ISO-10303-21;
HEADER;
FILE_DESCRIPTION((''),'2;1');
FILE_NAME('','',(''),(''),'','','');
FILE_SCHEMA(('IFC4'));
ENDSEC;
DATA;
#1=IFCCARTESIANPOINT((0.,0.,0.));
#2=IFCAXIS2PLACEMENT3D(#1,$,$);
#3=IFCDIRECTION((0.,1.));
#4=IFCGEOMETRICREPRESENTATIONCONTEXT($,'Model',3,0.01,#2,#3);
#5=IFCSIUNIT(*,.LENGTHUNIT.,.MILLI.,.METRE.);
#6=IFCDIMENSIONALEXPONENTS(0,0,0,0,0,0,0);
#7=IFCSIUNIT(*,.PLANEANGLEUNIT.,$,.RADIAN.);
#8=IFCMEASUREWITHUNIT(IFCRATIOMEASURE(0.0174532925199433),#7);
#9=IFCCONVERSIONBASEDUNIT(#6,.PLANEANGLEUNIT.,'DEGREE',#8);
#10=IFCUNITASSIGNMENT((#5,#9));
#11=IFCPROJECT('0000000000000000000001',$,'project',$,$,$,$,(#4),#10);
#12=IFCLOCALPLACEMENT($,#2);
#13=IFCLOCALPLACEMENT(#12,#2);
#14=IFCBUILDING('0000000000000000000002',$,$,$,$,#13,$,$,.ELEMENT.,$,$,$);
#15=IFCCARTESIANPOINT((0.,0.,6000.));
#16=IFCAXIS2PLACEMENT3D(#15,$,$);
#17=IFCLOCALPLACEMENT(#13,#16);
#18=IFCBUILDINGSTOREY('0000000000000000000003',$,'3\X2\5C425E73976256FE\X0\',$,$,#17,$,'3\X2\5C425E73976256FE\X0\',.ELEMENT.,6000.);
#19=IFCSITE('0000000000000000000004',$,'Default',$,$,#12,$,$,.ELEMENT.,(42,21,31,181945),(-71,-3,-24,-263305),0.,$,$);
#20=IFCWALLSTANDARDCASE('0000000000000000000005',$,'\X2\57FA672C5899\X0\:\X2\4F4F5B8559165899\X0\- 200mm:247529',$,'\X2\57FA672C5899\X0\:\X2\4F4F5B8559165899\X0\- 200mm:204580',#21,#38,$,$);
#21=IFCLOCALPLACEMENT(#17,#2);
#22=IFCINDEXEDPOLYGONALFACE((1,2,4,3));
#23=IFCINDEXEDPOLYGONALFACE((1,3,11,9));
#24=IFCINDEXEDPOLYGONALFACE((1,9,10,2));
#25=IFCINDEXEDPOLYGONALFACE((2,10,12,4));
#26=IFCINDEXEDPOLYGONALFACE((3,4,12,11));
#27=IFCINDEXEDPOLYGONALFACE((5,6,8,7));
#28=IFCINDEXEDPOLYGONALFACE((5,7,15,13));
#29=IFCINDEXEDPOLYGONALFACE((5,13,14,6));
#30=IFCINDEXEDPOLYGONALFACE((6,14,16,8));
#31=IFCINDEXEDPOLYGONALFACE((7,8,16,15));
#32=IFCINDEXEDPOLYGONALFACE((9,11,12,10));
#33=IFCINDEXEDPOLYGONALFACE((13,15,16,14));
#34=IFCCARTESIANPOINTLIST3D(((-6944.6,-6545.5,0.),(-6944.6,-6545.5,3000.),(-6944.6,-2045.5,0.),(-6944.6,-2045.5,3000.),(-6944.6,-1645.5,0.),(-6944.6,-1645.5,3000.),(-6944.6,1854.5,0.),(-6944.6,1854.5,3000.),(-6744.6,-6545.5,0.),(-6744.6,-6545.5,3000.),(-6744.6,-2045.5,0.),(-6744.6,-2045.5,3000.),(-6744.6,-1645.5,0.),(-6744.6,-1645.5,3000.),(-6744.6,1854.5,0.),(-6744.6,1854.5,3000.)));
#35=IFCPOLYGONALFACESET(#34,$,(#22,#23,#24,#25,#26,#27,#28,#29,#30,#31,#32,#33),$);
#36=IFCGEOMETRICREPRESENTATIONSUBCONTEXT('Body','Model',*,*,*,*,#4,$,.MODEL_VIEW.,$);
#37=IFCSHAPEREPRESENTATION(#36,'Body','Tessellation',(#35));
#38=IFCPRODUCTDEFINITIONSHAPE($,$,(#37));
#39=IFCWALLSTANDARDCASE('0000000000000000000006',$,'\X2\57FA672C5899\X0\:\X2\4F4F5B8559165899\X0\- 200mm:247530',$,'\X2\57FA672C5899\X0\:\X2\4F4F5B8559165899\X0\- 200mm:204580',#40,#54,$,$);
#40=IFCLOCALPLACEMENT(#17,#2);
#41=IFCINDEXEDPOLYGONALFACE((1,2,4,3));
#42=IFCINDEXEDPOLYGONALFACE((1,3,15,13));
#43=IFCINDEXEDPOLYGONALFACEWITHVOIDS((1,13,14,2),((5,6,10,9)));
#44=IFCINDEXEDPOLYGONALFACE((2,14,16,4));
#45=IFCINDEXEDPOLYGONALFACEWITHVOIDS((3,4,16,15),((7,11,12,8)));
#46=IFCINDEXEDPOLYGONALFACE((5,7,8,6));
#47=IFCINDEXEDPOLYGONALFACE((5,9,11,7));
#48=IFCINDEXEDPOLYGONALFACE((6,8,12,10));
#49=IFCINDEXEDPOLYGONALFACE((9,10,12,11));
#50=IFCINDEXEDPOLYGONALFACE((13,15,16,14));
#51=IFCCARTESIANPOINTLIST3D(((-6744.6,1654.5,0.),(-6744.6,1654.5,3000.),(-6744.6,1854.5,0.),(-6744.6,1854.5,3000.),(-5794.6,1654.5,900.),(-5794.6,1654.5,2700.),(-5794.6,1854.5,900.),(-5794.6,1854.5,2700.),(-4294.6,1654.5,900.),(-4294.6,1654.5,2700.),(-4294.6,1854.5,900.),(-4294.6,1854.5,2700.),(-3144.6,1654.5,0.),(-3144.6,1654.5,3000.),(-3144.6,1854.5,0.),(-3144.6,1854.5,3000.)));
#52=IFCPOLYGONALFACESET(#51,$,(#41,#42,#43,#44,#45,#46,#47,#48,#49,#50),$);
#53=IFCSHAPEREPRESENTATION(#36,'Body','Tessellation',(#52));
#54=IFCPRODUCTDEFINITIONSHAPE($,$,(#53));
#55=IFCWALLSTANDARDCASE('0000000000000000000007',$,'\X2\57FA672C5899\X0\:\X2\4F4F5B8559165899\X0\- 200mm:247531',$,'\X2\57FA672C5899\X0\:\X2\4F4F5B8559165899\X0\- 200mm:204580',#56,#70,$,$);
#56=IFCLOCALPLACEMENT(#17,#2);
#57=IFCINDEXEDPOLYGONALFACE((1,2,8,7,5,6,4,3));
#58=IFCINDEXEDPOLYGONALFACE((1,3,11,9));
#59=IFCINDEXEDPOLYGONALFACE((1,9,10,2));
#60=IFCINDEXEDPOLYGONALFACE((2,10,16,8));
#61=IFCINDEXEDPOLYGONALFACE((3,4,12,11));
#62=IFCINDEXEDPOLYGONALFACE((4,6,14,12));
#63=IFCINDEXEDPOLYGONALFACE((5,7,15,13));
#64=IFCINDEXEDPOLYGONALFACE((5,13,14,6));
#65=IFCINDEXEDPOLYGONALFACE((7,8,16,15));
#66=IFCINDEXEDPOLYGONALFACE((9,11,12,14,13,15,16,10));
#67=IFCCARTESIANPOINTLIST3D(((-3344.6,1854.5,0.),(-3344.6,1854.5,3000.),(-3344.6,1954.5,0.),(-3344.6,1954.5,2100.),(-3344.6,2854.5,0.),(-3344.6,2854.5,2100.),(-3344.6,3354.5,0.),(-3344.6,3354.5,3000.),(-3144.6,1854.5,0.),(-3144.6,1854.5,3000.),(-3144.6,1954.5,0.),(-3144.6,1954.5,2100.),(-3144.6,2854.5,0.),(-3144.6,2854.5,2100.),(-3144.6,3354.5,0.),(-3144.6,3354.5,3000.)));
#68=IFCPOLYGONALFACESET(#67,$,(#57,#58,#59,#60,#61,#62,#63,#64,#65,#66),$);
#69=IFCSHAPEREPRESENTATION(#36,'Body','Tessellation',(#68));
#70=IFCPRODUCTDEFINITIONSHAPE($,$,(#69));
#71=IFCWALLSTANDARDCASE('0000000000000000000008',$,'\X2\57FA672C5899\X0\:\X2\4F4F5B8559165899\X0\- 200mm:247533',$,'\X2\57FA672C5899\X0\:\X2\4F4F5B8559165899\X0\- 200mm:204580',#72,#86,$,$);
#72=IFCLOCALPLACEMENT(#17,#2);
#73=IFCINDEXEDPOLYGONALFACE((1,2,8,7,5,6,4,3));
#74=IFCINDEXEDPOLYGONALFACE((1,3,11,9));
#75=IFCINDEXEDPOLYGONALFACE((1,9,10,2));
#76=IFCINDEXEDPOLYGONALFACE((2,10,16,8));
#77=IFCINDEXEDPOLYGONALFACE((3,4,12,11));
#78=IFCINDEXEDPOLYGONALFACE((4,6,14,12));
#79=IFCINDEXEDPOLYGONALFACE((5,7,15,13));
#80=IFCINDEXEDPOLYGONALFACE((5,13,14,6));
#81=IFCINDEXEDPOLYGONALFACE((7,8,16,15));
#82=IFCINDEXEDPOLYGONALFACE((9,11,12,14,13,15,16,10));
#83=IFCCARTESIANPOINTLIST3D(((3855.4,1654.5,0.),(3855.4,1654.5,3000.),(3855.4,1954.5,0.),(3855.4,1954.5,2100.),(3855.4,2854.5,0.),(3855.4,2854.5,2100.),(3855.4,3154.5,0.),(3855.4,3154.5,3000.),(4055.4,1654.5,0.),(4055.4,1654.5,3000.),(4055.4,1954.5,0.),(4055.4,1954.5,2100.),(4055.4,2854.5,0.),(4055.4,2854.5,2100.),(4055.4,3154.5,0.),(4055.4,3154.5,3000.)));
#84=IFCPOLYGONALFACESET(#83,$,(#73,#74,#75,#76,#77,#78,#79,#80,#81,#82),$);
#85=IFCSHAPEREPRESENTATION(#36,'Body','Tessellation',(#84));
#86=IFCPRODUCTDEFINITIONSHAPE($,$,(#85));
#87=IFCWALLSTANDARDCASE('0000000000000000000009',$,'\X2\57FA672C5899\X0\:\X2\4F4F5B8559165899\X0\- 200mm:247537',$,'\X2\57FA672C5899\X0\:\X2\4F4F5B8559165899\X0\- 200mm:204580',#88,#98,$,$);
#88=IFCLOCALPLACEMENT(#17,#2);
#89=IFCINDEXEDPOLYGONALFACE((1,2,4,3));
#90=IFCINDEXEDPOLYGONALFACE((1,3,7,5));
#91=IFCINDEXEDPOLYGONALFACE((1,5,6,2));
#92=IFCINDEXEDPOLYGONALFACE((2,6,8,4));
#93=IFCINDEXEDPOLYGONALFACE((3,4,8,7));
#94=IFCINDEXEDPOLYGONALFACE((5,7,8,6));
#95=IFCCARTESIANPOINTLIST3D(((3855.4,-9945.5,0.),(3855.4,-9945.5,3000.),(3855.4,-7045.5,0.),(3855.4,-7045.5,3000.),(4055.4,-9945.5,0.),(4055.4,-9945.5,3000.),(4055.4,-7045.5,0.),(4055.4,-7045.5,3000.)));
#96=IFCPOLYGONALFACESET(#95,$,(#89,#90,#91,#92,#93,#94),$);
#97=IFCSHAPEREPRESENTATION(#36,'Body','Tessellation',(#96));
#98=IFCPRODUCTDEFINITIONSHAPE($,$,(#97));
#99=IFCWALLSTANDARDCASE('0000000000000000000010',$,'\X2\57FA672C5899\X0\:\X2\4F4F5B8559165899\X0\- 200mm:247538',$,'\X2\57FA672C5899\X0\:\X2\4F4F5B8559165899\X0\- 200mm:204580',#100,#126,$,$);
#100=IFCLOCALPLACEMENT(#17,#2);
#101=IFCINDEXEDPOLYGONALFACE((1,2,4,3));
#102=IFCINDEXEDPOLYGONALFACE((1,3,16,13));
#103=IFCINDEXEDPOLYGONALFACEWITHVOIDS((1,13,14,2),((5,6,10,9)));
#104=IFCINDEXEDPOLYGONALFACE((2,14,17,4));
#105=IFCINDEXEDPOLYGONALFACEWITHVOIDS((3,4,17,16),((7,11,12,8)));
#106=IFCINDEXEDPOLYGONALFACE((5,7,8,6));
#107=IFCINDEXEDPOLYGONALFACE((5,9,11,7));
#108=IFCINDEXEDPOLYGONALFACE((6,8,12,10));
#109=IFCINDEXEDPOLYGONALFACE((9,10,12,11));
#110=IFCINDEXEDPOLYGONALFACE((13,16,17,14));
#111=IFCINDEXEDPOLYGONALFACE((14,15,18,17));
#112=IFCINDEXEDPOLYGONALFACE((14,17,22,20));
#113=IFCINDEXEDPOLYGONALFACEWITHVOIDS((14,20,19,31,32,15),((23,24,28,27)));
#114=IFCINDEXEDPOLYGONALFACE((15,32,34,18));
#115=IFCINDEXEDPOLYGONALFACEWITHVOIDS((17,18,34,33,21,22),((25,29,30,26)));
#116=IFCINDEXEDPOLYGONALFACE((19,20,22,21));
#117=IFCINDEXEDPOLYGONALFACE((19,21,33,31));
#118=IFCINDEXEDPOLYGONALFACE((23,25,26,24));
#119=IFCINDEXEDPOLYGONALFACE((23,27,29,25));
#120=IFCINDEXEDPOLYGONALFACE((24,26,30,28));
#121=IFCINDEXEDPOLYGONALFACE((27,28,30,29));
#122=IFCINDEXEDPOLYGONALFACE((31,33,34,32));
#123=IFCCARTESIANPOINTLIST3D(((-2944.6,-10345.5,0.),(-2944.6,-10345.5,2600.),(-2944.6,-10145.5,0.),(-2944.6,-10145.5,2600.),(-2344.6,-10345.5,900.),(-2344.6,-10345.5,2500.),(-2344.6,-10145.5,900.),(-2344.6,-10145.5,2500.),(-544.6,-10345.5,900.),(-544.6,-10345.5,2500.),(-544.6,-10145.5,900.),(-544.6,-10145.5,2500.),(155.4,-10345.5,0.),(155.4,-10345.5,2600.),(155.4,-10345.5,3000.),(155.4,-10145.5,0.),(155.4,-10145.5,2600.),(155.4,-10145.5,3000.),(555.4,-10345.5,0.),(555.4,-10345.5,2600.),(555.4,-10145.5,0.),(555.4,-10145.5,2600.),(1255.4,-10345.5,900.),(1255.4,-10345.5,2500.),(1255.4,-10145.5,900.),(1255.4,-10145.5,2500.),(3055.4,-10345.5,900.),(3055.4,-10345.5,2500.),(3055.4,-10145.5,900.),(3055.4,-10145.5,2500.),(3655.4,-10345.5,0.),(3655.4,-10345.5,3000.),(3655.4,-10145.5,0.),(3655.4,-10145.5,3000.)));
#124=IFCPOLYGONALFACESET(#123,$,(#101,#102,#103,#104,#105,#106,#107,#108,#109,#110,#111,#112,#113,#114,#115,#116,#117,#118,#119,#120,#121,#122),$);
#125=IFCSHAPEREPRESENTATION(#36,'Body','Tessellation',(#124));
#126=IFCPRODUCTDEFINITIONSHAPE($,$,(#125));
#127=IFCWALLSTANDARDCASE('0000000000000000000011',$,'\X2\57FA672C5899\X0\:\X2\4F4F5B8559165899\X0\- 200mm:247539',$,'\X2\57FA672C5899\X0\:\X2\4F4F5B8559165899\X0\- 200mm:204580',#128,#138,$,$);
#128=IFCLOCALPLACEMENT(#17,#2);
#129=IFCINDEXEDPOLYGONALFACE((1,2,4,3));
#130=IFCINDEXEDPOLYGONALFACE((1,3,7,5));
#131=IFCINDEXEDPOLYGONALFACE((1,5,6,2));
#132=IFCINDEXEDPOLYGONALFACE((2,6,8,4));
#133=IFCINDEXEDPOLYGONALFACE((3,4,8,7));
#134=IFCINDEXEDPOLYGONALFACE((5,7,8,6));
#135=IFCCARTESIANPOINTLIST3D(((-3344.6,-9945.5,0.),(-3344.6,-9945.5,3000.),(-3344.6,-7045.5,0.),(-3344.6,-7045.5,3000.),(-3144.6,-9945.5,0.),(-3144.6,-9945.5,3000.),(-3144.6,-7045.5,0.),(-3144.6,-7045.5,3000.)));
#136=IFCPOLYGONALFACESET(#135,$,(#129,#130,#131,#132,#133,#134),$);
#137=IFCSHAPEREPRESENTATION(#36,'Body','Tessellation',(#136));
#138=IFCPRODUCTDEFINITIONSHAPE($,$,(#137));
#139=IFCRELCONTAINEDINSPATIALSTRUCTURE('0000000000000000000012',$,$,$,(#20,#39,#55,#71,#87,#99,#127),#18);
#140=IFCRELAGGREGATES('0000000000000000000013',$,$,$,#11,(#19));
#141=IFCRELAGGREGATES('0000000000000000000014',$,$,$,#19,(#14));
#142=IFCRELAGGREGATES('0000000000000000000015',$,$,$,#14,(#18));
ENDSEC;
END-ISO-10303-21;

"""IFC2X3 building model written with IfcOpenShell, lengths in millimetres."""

from ifc_helpers import new_model, entity, si_unit, converted_unit, direction, frame, frame_2d, origin, place, context, subcontext, project, spatial, polyline, rectangle, extrude, clip, bounded_halfspace, element, save


model = new_model("IFC2X3")

# Units and contexts
model_context = context("Model", 3, precision=0.01, world=origin(), true_north=direction((0.0, 1.0)))
body_context = subcontext(model_context, "Body", "Model", "MODEL_VIEW")
ifc_project = project(units=[si_unit("LENGTHUNIT", "METRE", prefix="MILLI"), converted_unit("PLANEANGLEUNIT", "DEGREE", entity("IfcRatioMeasure", 0.0174532925199433), si_unit("PLANEANGLEUNIT", "RADIAN"), dimensions=[0, 0, 0, 0, 0, 0, 0])], contexts=[model_context])

# Site, building, storey
site_placement = place(None, origin())
site = spatial("IfcSite", under=ifc_project, at=site_placement, Name="Default", CompositionType="ELEMENT", RefLatitude=(42, 21, 31, 181945), RefLongitude=(-71, -3, -24, -263305), RefElevation=0.0)
building_placement = place(site_placement, origin())
building = spatial("IfcBuilding", under=site, at=building_placement, CompositionType="ELEMENT")
storey_placement = place(building_placement, frame((0.0, 0.0, 6000.0)))
storey = spatial("IfcBuildingStorey", under=building, at=storey_placement, Name="3层平面图", LongName="3层平面图", CompositionType="ELEMENT", Elevation=6000.0)

# Walls, openings
wall_1_placement = place(storey_placement, frame((-6844.6, -6545.5, 0.0), z_axis=(0.0, 0.0, 1.0), x_axis=(0.0, 1.0, 0.0)))
wall_1 = element("IfcWallStandardCase", 1, at=wall_1_placement, inside=storey, Name="基本墙:住宅外墙- 200mm:247529", ObjectType="基本墙:住宅外墙- 200mm:204580", context=body_context, shape_type="Clipping", body=[
    clip(extrude(rectangle(XDim=8400.0, YDim=200.0, at=frame_2d((4200.0, 0.0), x_axis=(-1.0, 0.0))), origin(), (0.0, 0.0, 1.0), 3000.0), bounded_halfspace(frame((0.0, -100.0, 0.0), z_axis=(1.0, 0.0, 0.0), x_axis=(0.0, 0.0, -1.0)), True, frame((0.0, -100.0, 0.0), z_axis=(1.0, 0.0, 0.0), x_axis=(0.0, 0.0, -1.0)), polyline([(0.0, 0.0), (0.0, 200.0), (-3000.0, 200.0), (-3000.0, 0.0), (0.0, 0.0)]))),
])
opening_1_placement = place(storey_placement, frame((-6844.6, -6545.5, 0.0), z_axis=(0.0, 0.0, 1.0), x_axis=(0.0, 1.0, 0.0)))
element("IfcOpeningElement", 2, at=opening_1_placement, cuts=wall_1, ObjectType="Opening", context=body_context, shape_type="SweptSolid", body=[
    extrude(rectangle(XDim=3000.0, YDim=200.0, at=frame_2d((0.0, 0.0), x_axis=(1.0, 0.0))), frame((4500.0, 0.0, 1500.0), z_axis=(1.0, 0.0, 0.0), x_axis=(0.0, 0.0, -1.0)), (0.0, 0.0, 1.0), 400.0),
])
wall_2_placement = place(storey_placement, frame((-6744.6, 1754.5, 0.0)))
wall_2 = element("IfcWallStandardCase", 3, at=wall_2_placement, inside=storey, Name="基本墙:住宅外墙- 200mm:247530", ObjectType="基本墙:住宅外墙- 200mm:204580", context=body_context, shape_type="SweptSolid", body=[
    extrude(rectangle(XDim=3600.0, YDim=200.0, at=frame_2d((1800.0, 0.0), x_axis=(-1.0, 0.0))), origin(), (0.0, 0.0, 1.0), 3000.0),
])
opening_2_placement = place(wall_2_placement, frame((950.0, -100.0, 900.0)))
element("IfcOpeningElement", 4, at=opening_2_placement, cuts=wall_2, ObjectType="Opening", context=body_context, shape_type="SweptSolid", body=[
    extrude(rectangle(XDim=1800.0, YDim=1500.0, at=frame_2d((900.0, 750.0), x_axis=(1.0, 0.0))), frame((0.0, 0.0, 0.0), z_axis=(0.0, 1.0, 0.0), x_axis=(0.0, 0.0, 1.0)), (0.0, 0.0, 1.0), 200.0),
])
wall_3_placement = place(storey_placement, frame((-3244.6, 1854.5, 0.0), z_axis=(0.0, 0.0, 1.0), x_axis=(0.0, 1.0, 0.0)))
wall_3 = element("IfcWallStandardCase", 5, at=wall_3_placement, inside=storey, Name="基本墙:住宅外墙- 200mm:247531", ObjectType="基本墙:住宅外墙- 200mm:204580", context=body_context, shape_type="SweptSolid", body=[
    extrude(rectangle(XDim=1500.0, YDim=200.0, at=frame_2d((750.0, 0.0), x_axis=(-1.0, 0.0))), origin(), (0.0, 0.0, 1.0), 3000.0),
])
opening_3_placement = place(wall_3_placement, frame((100.0, -100.0, 0.0)))
element("IfcOpeningElement", 6, at=opening_3_placement, cuts=wall_3, ObjectType="Opening", context=body_context, shape_type="SweptSolid", body=[
    extrude(rectangle(XDim=2100.0, YDim=900.0, at=frame_2d((1050.0, 450.0), x_axis=(1.0, 0.0))), frame((0.0, 0.0, 0.0), z_axis=(0.0, 1.0, 0.0), x_axis=(0.0, 0.0, 1.0)), (0.0, 0.0, 1.0), 200.0),
])
wall_4_placement = place(storey_placement, frame((3955.4, 3154.5, 0.0), z_axis=(0.0, 0.0, 1.0), x_axis=(0.0, -1.0, 0.0)))
wall_4 = element("IfcWallStandardCase", 7, at=wall_4_placement, inside=storey, Name="基本墙:住宅外墙- 200mm:247533", ObjectType="基本墙:住宅外墙- 200mm:204580", context=body_context, shape_type="SweptSolid", body=[
    extrude(rectangle(XDim=1500.0, YDim=200.0, at=frame_2d((750.0, 0.0), x_axis=(-1.0, 0.0))), origin(), (0.0, 0.0, 1.0), 3000.0),
])
opening_4_placement = place(wall_4_placement, frame((300.0, -100.0, 0.0)))
element("IfcOpeningElement", 8, at=opening_4_placement, cuts=wall_4, ObjectType="Opening", context=body_context, shape_type="SweptSolid", body=[
    extrude(rectangle(XDim=2100.0, YDim=900.0, at=frame_2d((1050.0, 450.0), x_axis=(1.0, 0.0))), frame((0.0, 0.0, 0.0), z_axis=(0.0, 1.0, 0.0), x_axis=(0.0, 0.0, 1.0)), (0.0, 0.0, 1.0), 200.0),
])

# Wall
wall_5_placement = place(storey_placement, frame((3955.4, -7045.5, 0.0), z_axis=(0.0, 0.0, 1.0), x_axis=(0.0, -1.0, 0.0)))
element("IfcWallStandardCase", 9, at=wall_5_placement, inside=storey, Name="基本墙:住宅外墙- 200mm:247537", ObjectType="基本墙:住宅外墙- 200mm:204580", context=body_context, shape_type="Clipping", body=[
    clip(clip(extrude(rectangle(XDim=2900.0, YDim=200.0, at=frame_2d((1450.0, 0.0), x_axis=(-1.0, 0.0))), origin(), (0.0, 0.0, 1.0), 3000.0), bounded_halfspace(frame((0.0, -100.0, 0.0), z_axis=(-1.0, 0.0, 0.0), x_axis=(0.0, 0.0, -1.0)), False, frame((0.0, -100.0, 0.0), z_axis=(-1.0, 0.0, 0.0), x_axis=(0.0, 0.0, -1.0)), polyline([(0.0, 0.0), (-3000.0, 0.0), (-3000.0, -200.0), (0.0, -200.0), (0.0, 0.0)]))), bounded_halfspace(frame((2900.0, -100.0, 3000.0), z_axis=(1.0, 0.0, 0.0), x_axis=(0.0, 0.0, -1.0)), False, frame((2900.0, -100.0, 3000.0), z_axis=(1.0, 0.0, 0.0), x_axis=(0.0, 0.0, -1.0)), polyline([(0.0, 0.0), (3000.0, 0.0), (3000.0, 200.0), (0.0, 200.0), (0.0, 0.0)]))),
])

# Wall, openings
wall_6_placement = place(storey_placement, frame((3655.4, -10245.5, 0.0), z_axis=(0.0, 0.0, 1.0), x_axis=(-1.0, 0.0, 0.0)))
wall_6 = element("IfcWallStandardCase", 10, at=wall_6_placement, inside=storey, Name="基本墙:住宅外墙- 200mm:247538", ObjectType="基本墙:住宅外墙- 200mm:204580", context=body_context, shape_type="Clipping", body=[
    clip(clip(clip(extrude(rectangle(XDim=6600.0, YDim=200.0, at=frame_2d((3300.0, 0.0), x_axis=(-1.0, 0.0))), origin(), (0.0, 0.0, 1.0), 3000.0), bounded_halfspace(frame((0.0, -100.0, 0.0), z_axis=(-1.0, 0.0, 0.0), x_axis=(0.0, 0.0, -1.0)), False, frame((0.0, -100.0, 0.0), z_axis=(-1.0, 0.0, 0.0), x_axis=(0.0, 0.0, -1.0)), polyline([(0.0, 0.0), (-3000.0, 0.0), (-3000.0, -200.0), (0.0, -200.0), (0.0, 0.0)]))), bounded_halfspace(frame((6600.0, -100.0, 0.0), z_axis=(-1.0, 0.0, 0.0), x_axis=(0.0, 0.0, -1.0)), True, frame((6600.0, -100.0, 0.0), z_axis=(-1.0, 0.0, 0.0), x_axis=(0.0, 0.0, -1.0)), polyline([(0.0, 0.0), (-2600.0, 0.0), (-2600.0, -200.0), (0.0, -200.0), (0.0, 0.0)]))), bounded_halfspace(frame((3500.0, -100.0, 2600.0), z_axis=(0.0, 0.0, -1.0), x_axis=(1.0, 0.0, 0.0)), True, frame((3500.0, -100.0, 2600.0), z_axis=(0.0, 0.0, -1.0), x_axis=(1.0, 0.0, 0.0)), polyline([(0.0, 0.0), (0.0, -200.0), (3100.0, -200.0), (3100.0, 0.0), (0.0, 0.0)]))),
])
opening_5_placement = place(wall_6_placement, frame((2400.0, 100.0, 900.0)))
element("IfcOpeningElement", 11, at=opening_5_placement, cuts=wall_6, ObjectType="Opening", context=body_context, shape_type="SweptSolid", body=[
    extrude(rectangle(XDim=1600.0, YDim=1800.0, at=frame_2d((800.0, 900.0), x_axis=(1.0, 0.0))), frame((0.0, 0.0, 0.0), z_axis=(0.0, -1.0, 0.0), x_axis=(0.0, 0.0, 1.0)), (0.0, 0.0, 1.0), 200.0),
])
opening_6_placement = place(wall_6_placement, frame((6000.0, 100.0, 900.0)))
element("IfcOpeningElement", 12, at=opening_6_placement, cuts=wall_6, ObjectType="Opening", context=body_context, shape_type="SweptSolid", body=[
    extrude(rectangle(XDim=1600.0, YDim=1800.0, at=frame_2d((800.0, 900.0), x_axis=(1.0, 0.0))), frame((0.0, 0.0, 0.0), z_axis=(0.0, -1.0, 0.0), x_axis=(0.0, 0.0, 1.0)), (0.0, 0.0, 1.0), 200.0),
])
opening_7_placement = place(storey_placement, frame((3655.4, -10245.5, 0.0), z_axis=(0.0, 0.0, 1.0), x_axis=(-1.0, 0.0, 0.0)))
element("IfcOpeningElement", 13, at=opening_7_placement, cuts=wall_6, ObjectType="Opening", context=body_context, shape_type="SweptSolid", body=[
    extrude(rectangle(XDim=2600.0, YDim=200.0, at=frame_2d((0.0, 0.0), x_axis=(0.0, 1.0))), frame((3500.0, 0.0, 1300.0), z_axis=(-1.0, 0.0, 0.0), x_axis=(0.0, -1.0, 0.0)), (0.0, 0.0, 1.0), 400.0),
])

# Wall
wall_7_placement = place(storey_placement, frame((-3244.6, -9945.5, 0.0), z_axis=(0.0, 0.0, 1.0), x_axis=(0.0, 1.0, 0.0)))
element("IfcWallStandardCase", 14, at=wall_7_placement, inside=storey, Name="基本墙:住宅外墙- 200mm:247539", ObjectType="基本墙:住宅外墙- 200mm:204580", context=body_context, shape_type="Clipping", body=[
    clip(clip(extrude(rectangle(XDim=2900.0, YDim=200.0, at=frame_2d((1450.0, 0.0), x_axis=(-1.0, 0.0))), origin(), (0.0, 0.0, 1.0), 3000.0), bounded_halfspace(frame((0.0, -100.0, 0.0), z_axis=(1.0, 0.0, 0.0), x_axis=(0.0, 0.0, -1.0)), True, frame((0.0, -100.0, 0.0), z_axis=(1.0, 0.0, 0.0), x_axis=(0.0, 0.0, -1.0)), polyline([(0.0, 0.0), (0.0, 200.0), (-3000.0, 200.0), (-3000.0, 0.0), (0.0, 0.0)]))), bounded_halfspace(frame((2900.0, -100.0, 3000.0), z_axis=(-1.0, 0.0, 0.0), x_axis=(0.0, 0.0, -1.0)), True, frame((2900.0, -100.0, 3000.0), z_axis=(-1.0, 0.0, 0.0), x_axis=(0.0, 0.0, -1.0)), polyline([(0.0, 0.0), (0.0, -200.0), (3000.0, -200.0), (3000.0, 0.0), (0.0, 0.0)]))),
])

save(model, "model.ifc")
